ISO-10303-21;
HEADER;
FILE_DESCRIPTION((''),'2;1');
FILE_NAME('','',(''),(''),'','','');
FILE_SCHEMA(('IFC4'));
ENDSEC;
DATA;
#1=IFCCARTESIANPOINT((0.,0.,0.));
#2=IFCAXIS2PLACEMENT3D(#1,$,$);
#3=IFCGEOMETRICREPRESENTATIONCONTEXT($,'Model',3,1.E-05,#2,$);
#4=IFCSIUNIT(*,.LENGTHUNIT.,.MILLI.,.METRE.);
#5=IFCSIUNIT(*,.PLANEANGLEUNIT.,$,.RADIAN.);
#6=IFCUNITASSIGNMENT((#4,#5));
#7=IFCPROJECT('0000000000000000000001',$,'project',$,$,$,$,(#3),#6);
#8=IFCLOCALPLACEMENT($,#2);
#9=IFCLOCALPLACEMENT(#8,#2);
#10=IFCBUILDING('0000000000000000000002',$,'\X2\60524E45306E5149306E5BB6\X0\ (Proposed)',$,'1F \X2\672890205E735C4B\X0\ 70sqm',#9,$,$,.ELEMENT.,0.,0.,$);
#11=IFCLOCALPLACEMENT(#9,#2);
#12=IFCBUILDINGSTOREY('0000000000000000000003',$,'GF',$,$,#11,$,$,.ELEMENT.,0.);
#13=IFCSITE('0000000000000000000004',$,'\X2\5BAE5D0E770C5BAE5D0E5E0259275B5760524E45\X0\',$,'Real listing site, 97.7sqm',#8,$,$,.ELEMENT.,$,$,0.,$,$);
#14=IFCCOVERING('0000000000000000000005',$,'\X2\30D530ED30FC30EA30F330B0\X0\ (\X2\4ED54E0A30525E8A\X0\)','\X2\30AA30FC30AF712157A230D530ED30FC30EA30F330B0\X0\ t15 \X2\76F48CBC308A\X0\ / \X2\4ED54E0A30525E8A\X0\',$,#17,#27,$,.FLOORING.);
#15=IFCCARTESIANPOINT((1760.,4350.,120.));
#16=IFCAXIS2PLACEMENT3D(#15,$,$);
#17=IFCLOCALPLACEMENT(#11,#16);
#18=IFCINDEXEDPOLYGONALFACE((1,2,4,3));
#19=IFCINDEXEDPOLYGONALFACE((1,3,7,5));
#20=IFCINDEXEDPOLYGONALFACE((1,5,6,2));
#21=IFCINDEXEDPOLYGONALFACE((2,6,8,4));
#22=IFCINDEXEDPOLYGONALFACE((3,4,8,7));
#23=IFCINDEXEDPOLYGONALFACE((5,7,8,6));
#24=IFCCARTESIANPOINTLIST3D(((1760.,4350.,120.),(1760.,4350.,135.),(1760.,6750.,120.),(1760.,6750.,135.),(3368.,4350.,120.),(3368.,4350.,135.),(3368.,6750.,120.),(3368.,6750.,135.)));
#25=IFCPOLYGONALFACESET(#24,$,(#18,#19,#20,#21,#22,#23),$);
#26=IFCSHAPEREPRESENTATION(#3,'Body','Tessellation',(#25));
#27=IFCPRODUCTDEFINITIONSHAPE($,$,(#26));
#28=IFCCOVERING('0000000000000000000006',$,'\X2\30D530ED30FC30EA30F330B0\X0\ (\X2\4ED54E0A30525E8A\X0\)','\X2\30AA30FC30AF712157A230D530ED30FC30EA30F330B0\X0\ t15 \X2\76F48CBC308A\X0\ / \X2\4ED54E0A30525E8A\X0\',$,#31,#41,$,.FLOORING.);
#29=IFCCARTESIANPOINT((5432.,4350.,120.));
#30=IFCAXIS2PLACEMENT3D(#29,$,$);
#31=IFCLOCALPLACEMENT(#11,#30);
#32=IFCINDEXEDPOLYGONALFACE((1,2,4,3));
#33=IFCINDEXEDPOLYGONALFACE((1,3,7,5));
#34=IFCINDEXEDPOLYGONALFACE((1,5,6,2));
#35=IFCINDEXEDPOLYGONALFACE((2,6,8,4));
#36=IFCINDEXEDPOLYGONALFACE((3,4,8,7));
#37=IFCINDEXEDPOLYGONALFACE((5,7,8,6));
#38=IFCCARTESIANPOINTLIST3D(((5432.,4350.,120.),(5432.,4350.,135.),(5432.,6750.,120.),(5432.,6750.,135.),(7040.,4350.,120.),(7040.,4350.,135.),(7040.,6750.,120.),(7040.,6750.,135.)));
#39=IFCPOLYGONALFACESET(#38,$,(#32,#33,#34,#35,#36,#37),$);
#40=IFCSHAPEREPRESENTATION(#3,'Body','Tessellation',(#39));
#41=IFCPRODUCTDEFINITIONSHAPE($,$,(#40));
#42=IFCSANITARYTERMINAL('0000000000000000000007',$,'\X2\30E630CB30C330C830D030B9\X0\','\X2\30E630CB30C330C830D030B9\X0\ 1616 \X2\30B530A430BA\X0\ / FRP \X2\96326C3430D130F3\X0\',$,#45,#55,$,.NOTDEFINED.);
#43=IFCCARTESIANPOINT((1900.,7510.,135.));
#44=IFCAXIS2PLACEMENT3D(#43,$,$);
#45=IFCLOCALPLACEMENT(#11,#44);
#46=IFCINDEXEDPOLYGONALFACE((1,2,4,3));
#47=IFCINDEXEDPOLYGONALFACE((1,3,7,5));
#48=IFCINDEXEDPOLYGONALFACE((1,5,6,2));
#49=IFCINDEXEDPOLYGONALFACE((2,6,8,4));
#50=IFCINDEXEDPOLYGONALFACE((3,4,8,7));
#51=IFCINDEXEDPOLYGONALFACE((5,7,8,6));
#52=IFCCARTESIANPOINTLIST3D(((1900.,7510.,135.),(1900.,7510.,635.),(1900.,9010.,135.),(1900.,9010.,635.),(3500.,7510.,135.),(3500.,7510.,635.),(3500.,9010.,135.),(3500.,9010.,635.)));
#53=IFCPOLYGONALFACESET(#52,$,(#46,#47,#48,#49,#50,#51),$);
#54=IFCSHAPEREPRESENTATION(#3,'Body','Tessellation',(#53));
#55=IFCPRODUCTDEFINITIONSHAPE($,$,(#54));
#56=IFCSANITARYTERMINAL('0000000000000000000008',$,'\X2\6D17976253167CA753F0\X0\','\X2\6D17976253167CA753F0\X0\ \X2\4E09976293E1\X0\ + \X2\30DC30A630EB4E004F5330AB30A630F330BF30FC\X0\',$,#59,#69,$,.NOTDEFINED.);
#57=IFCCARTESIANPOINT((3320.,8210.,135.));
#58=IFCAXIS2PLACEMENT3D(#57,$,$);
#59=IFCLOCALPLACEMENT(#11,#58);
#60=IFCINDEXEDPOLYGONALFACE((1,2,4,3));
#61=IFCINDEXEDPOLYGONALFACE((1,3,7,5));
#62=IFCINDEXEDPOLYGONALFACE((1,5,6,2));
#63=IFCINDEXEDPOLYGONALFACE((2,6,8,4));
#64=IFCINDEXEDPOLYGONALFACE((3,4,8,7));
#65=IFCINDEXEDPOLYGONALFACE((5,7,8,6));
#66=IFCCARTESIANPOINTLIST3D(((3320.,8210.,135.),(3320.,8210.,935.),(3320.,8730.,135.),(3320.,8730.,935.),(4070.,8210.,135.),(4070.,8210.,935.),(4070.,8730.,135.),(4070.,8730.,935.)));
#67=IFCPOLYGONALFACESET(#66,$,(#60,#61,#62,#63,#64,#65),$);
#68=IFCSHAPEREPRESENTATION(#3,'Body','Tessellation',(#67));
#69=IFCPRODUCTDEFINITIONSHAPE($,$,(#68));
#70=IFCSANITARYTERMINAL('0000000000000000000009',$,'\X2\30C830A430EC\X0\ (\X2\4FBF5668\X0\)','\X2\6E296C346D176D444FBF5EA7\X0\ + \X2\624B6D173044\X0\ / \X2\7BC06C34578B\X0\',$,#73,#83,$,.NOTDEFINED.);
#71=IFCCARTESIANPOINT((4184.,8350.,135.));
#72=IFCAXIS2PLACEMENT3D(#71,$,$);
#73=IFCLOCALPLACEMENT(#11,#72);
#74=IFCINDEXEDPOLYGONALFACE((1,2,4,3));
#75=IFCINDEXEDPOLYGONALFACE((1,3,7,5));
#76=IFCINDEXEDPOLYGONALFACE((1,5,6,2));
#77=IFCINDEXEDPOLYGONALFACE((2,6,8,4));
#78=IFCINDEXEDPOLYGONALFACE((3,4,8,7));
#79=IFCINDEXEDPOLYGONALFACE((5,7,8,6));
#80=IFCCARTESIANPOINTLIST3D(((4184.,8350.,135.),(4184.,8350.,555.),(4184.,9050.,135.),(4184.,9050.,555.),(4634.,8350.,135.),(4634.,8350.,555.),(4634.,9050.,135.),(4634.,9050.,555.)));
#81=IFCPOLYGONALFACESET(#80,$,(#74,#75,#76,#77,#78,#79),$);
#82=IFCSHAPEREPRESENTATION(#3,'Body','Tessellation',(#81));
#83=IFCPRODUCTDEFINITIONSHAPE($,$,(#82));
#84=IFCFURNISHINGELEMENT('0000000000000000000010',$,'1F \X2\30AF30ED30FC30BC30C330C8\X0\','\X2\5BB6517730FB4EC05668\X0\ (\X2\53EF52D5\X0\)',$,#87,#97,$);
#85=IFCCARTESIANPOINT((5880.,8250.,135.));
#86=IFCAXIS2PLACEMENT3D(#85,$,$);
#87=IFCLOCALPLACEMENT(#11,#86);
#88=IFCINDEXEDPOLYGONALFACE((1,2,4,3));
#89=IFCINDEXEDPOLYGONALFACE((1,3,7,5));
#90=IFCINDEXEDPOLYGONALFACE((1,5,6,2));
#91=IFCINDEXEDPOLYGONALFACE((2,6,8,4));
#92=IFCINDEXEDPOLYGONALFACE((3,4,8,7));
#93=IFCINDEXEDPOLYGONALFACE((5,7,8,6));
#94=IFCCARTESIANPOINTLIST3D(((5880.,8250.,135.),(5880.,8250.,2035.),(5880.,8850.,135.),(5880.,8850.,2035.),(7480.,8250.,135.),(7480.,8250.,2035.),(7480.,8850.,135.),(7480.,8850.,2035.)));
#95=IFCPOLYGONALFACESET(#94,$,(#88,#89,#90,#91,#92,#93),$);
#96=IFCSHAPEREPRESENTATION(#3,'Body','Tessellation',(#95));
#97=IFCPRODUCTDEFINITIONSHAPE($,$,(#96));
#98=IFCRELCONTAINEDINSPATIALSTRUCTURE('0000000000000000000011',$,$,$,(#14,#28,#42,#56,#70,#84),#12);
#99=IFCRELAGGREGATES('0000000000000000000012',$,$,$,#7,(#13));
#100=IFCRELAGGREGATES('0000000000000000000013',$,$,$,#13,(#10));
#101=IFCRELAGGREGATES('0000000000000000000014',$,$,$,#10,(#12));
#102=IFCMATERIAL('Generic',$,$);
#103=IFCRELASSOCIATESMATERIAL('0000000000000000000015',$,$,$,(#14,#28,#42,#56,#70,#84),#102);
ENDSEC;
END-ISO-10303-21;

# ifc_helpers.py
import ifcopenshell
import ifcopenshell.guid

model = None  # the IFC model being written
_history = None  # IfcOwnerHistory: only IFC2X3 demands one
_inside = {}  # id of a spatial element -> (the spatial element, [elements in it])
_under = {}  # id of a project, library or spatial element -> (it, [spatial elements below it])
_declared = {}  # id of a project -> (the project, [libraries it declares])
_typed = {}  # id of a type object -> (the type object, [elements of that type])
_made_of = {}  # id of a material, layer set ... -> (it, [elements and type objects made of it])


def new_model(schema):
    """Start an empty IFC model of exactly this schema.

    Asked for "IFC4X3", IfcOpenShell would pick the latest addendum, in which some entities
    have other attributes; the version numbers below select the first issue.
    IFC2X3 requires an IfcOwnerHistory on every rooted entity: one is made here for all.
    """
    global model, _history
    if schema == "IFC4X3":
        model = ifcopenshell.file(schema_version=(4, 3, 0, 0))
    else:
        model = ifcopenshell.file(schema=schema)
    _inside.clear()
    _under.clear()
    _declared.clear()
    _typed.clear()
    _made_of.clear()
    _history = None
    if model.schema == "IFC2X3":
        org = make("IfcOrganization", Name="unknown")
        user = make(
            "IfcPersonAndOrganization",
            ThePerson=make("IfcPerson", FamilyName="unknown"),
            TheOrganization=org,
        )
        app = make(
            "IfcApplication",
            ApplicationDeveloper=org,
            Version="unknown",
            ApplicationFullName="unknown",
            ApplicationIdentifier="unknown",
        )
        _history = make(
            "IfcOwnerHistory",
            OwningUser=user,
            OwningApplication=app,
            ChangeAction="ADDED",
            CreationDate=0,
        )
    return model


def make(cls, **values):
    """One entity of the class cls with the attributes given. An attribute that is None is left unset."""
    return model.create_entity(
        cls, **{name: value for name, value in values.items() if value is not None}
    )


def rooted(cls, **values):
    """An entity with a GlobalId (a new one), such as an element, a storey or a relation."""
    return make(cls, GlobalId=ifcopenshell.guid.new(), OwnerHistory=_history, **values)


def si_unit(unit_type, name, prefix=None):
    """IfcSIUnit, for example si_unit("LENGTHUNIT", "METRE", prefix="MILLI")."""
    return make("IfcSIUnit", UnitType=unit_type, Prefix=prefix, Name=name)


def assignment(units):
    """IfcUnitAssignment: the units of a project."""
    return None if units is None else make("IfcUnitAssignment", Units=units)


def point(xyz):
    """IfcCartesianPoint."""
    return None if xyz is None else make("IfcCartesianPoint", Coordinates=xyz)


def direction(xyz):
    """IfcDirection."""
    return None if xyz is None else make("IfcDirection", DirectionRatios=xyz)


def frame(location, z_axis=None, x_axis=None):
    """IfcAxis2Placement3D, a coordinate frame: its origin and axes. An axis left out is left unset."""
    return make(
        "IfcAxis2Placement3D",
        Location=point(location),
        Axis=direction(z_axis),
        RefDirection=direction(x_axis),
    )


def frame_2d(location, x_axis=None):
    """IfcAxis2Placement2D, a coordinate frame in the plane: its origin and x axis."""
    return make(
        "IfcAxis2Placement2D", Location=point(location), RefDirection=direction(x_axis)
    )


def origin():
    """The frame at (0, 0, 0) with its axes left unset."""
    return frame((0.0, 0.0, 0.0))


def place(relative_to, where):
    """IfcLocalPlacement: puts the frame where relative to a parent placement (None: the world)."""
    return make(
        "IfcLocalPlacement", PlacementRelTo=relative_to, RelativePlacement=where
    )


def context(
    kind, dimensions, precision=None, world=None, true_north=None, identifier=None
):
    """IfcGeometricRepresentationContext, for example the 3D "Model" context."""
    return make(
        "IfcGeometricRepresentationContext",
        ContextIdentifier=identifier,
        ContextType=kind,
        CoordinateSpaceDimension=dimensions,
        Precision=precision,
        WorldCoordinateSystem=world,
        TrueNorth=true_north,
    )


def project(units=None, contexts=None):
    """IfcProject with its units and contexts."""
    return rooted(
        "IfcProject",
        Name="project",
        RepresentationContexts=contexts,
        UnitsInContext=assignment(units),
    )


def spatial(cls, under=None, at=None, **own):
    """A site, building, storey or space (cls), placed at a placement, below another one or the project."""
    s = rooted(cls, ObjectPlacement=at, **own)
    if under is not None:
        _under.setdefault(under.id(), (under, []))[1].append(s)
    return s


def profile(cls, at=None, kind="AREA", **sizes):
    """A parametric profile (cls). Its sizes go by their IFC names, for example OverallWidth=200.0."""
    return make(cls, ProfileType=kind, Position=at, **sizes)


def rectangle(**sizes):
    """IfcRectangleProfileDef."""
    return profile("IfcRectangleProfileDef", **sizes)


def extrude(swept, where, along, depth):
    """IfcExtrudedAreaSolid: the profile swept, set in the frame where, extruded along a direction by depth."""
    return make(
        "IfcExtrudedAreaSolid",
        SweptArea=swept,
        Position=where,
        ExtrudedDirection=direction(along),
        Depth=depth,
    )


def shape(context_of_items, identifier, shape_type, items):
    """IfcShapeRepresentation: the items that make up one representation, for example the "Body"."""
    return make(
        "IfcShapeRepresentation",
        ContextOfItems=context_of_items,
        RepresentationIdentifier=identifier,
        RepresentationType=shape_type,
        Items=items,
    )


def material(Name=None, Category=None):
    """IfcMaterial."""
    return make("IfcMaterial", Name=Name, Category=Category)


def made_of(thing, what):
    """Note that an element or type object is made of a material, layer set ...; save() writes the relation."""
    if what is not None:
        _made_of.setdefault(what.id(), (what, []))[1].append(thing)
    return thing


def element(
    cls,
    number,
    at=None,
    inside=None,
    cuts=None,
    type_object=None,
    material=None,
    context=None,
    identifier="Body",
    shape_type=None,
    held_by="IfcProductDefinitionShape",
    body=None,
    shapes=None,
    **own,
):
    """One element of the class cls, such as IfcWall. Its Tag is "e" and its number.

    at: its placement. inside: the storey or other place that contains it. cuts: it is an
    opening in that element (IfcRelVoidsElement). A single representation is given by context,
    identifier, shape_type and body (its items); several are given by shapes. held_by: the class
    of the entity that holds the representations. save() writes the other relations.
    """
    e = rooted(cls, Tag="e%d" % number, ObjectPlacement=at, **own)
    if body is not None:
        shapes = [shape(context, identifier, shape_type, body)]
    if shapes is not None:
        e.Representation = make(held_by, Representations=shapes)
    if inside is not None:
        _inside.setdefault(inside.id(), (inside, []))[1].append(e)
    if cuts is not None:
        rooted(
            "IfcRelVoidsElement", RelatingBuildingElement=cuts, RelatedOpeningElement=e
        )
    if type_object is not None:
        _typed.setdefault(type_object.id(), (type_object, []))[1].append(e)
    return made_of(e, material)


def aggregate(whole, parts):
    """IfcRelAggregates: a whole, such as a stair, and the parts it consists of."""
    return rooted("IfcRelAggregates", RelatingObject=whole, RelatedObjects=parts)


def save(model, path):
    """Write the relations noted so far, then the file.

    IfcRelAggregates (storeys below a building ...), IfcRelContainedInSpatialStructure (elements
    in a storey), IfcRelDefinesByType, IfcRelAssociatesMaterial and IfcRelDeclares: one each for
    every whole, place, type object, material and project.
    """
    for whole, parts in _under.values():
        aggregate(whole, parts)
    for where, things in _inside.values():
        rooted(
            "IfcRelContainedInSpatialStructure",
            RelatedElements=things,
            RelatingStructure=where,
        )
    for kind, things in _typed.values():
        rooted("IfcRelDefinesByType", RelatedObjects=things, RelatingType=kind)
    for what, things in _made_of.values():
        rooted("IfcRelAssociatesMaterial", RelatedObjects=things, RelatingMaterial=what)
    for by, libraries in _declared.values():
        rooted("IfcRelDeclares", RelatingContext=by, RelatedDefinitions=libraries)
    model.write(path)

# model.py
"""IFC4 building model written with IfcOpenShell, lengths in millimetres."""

from ifc_helpers import new_model, si_unit, frame, frame_2d, origin, place, context, project, spatial, rectangle, extrude, material, element, save


model = new_model("IFC4")

# Units and contexts
model_context = context("Model", 3, precision=1e-05, world=origin())
ifc_project = project(units=[si_unit("LENGTHUNIT", "METRE", prefix="MILLI"), si_unit("PLANEANGLEUNIT", "RADIAN")], contexts=[model_context])

# Site, building, storey
site_placement = place(None, origin())
site = spatial("IfcSite", under=ifc_project, at=site_placement, Name="宮崎県宮崎市大字恒久", ObjectType="Real listing site, 97.7sqm", CompositionType="ELEMENT", RefElevation=0.0)
building_placement = place(site_placement, origin())
building = spatial("IfcBuilding", under=site, at=building_placement, Name="恒久の光の家 (Proposed)", ObjectType="1F 木造平屋 70sqm", CompositionType="ELEMENT", ElevationOfRefHeight=0.0, ElevationOfTerrain=0.0)
storey_placement = place(building_placement, origin())
storey = spatial("IfcBuildingStorey", under=building, at=storey_placement, Name="GF", CompositionType="ELEMENT", Elevation=0.0)

# Coverings
ifc_material_1 = material(Name="Generic")
covering_1_placement = place(storey_placement, frame((1760.0, 4350.0, 120.0)))
element("IfcCovering", 1, at=covering_1_placement, inside=storey, material=ifc_material_1, Name="フローリング (仕上げ床)", Description="オーク無垢フローリング t15 直貼り / 仕上げ床", PredefinedType="FLOORING", context=model_context, shape_type="SweptSolid", body=[
    extrude(rectangle(XDim=1608.0, YDim=2400.0, at=frame_2d((804.0, 1200.0))), frame((1760.0, 4350.0, 120.0)), (0.0, 0.0, 1.0), 15.0),
])
covering_2_placement = place(storey_placement, frame((5432.0, 4350.0, 120.0)))
element("IfcCovering", 2, at=covering_2_placement, inside=storey, material=ifc_material_1, Name="フローリング (仕上げ床)", Description="オーク無垢フローリング t15 直貼り / 仕上げ床", PredefinedType="FLOORING", context=model_context, shape_type="SweptSolid", body=[
    extrude(rectangle(XDim=1608.0, YDim=2400.0, at=frame_2d((804.0, 1200.0))), frame((5432.0, 4350.0, 120.0)), (0.0, 0.0, 1.0), 15.0),
])

# Sanitary terminals
sanitary_terminal_1_placement = place(storey_placement, frame((1900.0, 7510.0, 135.0)))
element("IfcSanitaryTerminal", 3, at=sanitary_terminal_1_placement, inside=storey, material=ifc_material_1, Name="ユニットバス", Description="ユニットバス 1616 サイズ / FRP 防水パン", PredefinedType="NOTDEFINED", context=model_context, shape_type="SweptSolid", body=[
    extrude(rectangle(XDim=1600.0, YDim=1500.0, at=frame_2d((800.0, 750.0))), frame((1900.0, 7510.0, 135.0)), (0.0, 0.0, 1.0), 500.0),
])
sanitary_terminal_2_placement = place(storey_placement, frame((3320.0, 8210.0, 135.0)))
element("IfcSanitaryTerminal", 4, at=sanitary_terminal_2_placement, inside=storey, material=ifc_material_1, Name="洗面化粧台", Description="洗面化粧台 三面鏡 + ボウル一体カウンター", PredefinedType="NOTDEFINED", context=model_context, shape_type="SweptSolid", body=[
    extrude(rectangle(XDim=750.0, YDim=520.0, at=frame_2d((375.0, 260.0))), frame((3320.0, 8210.0, 135.0)), (0.0, 0.0, 1.0), 800.0),
])
sanitary_terminal_3_placement = place(storey_placement, frame((4184.0, 8350.0, 135.0)))
element("IfcSanitaryTerminal", 5, at=sanitary_terminal_3_placement, inside=storey, material=ifc_material_1, Name="トイレ (便器)", Description="温水洗浄便座 + 手洗い / 節水型", PredefinedType="NOTDEFINED", context=model_context, shape_type="SweptSolid", body=[
    extrude(rectangle(XDim=450.0, YDim=700.0, at=frame_2d((225.0, 350.0))), frame((4184.0, 8350.0, 135.0)), (0.0, 0.0, 1.0), 420.0),
])

# Furnishing element
furnishing_placement = place(storey_placement, frame((5880.0, 8250.0, 135.0)))
element("IfcFurnishingElement", 6, at=furnishing_placement, inside=storey, material=ifc_material_1, Name="1F クローゼット", Description="家具・什器 (可動)", context=model_context, shape_type="SweptSolid", body=[
    extrude(rectangle(XDim=1600.0, YDim=600.0, at=frame_2d((800.0, 300.0))), frame((5880.0, 8250.0, 135.0)), (0.0, 0.0, 1.0), 1900.0),
])

save(model, "model.ifc")
